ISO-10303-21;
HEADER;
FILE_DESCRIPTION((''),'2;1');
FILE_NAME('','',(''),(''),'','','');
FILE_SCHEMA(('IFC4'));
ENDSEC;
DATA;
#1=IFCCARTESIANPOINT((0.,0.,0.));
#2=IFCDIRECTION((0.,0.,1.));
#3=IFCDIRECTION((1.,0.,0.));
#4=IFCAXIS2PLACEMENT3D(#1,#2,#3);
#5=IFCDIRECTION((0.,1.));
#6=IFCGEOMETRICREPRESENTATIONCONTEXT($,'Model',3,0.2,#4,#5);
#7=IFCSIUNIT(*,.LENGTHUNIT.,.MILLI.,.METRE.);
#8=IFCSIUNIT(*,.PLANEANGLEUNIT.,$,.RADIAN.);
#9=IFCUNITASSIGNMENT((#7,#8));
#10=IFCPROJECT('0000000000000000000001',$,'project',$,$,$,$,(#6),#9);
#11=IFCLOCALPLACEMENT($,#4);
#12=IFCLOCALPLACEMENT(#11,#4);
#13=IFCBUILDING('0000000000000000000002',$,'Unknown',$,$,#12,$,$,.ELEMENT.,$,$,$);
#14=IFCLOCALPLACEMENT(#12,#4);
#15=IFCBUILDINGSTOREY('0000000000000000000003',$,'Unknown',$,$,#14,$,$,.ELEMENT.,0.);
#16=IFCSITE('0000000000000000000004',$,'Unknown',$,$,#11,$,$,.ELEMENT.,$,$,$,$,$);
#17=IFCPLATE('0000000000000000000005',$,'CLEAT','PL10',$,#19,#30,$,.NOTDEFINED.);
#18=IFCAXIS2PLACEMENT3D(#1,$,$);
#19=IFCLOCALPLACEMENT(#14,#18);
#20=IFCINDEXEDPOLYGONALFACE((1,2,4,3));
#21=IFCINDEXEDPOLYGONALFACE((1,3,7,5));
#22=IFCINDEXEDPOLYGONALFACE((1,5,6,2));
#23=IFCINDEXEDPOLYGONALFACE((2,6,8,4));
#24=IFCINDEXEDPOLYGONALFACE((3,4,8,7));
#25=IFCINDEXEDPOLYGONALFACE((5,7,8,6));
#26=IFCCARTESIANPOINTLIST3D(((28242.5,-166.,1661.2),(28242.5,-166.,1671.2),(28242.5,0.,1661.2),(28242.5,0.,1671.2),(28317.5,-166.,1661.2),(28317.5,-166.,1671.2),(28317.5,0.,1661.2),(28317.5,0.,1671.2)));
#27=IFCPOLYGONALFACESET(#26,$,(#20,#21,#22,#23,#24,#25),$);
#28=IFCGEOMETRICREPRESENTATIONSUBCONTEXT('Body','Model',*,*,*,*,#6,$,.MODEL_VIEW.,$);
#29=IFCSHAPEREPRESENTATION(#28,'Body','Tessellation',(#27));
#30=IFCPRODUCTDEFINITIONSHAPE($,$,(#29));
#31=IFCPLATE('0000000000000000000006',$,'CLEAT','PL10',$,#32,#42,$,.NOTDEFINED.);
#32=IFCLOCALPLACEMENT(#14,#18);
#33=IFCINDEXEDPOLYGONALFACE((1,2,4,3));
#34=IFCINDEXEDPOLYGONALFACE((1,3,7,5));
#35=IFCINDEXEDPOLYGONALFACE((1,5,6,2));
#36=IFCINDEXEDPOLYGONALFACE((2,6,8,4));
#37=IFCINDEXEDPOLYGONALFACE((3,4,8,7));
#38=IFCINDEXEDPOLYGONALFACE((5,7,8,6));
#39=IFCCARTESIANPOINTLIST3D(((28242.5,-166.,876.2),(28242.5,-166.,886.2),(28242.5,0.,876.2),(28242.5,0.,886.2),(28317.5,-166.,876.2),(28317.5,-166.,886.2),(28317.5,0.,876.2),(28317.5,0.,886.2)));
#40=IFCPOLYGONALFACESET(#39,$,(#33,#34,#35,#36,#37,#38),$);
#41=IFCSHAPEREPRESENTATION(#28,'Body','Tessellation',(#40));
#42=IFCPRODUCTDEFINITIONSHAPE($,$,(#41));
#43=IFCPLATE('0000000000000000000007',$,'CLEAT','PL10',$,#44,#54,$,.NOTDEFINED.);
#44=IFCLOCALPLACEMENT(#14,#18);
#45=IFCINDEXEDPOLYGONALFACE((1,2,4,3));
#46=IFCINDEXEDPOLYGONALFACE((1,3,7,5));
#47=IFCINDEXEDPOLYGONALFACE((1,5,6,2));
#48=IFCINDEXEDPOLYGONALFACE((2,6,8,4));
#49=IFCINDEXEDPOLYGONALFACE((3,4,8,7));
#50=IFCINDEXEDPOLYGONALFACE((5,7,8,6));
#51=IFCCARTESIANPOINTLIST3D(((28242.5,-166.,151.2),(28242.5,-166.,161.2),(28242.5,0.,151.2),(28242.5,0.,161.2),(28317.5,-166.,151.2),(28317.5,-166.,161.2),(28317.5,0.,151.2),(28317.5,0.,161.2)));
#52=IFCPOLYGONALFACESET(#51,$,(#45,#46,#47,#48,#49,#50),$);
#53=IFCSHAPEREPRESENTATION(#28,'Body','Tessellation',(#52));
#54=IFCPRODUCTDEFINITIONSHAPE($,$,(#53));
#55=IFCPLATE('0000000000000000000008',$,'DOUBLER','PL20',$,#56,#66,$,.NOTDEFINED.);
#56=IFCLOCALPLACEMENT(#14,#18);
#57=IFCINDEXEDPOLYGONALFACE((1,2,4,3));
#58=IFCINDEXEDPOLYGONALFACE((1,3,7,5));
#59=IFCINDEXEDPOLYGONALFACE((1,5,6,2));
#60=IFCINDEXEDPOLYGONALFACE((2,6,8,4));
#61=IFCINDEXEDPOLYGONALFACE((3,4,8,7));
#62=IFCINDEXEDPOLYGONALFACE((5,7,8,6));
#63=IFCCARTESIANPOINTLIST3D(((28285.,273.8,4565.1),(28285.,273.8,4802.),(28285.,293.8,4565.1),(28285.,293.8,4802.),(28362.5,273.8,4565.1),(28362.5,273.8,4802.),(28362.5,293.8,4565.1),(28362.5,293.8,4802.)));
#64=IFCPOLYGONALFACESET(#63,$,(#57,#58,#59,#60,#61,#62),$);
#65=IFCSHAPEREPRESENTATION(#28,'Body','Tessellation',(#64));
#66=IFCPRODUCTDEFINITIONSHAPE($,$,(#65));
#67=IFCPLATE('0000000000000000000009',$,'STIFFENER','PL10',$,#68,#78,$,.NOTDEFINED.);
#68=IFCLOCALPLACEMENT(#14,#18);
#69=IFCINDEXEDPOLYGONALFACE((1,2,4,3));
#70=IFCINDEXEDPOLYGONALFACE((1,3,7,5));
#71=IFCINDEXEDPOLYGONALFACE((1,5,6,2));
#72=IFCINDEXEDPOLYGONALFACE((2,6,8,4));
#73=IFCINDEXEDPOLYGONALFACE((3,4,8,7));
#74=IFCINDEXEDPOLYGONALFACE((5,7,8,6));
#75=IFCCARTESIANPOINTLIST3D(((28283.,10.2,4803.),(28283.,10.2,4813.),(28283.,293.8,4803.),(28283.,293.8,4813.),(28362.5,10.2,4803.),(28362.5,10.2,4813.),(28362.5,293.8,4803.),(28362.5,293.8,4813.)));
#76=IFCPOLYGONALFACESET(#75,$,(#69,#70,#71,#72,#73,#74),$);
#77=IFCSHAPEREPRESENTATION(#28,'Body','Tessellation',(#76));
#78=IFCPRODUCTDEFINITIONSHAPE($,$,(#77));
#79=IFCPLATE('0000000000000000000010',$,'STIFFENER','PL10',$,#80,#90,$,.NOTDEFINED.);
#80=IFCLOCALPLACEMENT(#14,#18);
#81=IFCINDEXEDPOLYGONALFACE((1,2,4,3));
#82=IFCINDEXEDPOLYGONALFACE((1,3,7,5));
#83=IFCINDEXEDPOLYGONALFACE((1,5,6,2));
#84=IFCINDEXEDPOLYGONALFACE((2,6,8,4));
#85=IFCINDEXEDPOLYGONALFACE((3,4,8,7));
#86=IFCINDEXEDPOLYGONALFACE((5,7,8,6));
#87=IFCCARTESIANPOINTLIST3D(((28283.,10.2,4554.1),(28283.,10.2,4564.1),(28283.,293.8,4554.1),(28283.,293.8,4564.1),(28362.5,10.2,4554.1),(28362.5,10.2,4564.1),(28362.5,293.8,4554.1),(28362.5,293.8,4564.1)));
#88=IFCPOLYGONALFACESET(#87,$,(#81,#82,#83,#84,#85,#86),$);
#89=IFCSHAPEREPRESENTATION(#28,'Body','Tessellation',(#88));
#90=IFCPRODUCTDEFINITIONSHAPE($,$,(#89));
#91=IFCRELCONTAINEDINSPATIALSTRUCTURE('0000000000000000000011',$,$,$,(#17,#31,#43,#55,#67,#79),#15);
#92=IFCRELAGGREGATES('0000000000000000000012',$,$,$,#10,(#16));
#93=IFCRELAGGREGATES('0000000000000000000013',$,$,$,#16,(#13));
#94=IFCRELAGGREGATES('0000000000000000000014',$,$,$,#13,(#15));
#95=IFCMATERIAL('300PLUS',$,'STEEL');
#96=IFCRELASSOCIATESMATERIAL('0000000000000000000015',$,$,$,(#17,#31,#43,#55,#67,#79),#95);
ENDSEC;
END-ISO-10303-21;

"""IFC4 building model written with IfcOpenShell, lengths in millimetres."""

from ifc_helpers import new_model, si_unit, direction, frame, origin_with_axes, place, context, subcontext, project, spatial, line, indexed_curve, outline, extrude, material, element, save


model = new_model("IFC4")

# Units and contexts
model_context = context("Model", 3, precision=0.2, world=origin_with_axes(), true_north=direction((0.0, 1.0)))
body_context = subcontext(model_context, "Body", "Model", "MODEL_VIEW")
ifc_project = project(units=[si_unit("LENGTHUNIT", "METRE", prefix="MILLI"), si_unit("PLANEANGLEUNIT", "RADIAN")], contexts=[model_context])

# Site, building, storey
site_placement = place(None, origin_with_axes())
site = spatial("IfcSite", under=ifc_project, at=site_placement, Name="Unknown", CompositionType="ELEMENT")
building_placement = place(site_placement, origin_with_axes())
building = spatial("IfcBuilding", under=site, at=building_placement, Name="Unknown", CompositionType="ELEMENT")
storey_placement = place(building_placement, origin_with_axes())
storey = spatial("IfcBuildingStorey", under=building, at=storey_placement, Name="Unknown", CompositionType="ELEMENT", Elevation=0.0)

# Plates
ifc_material_1 = material(Name="300PLUS", Category="STEEL")
for number, where, z_axis, x_axis, name in (
    (1, (28317.5, 0.0, 1666.2), (0.0, 0.0, 1.0), (-1.0, 0.0, 0.0), "CLEAT"),
    (2, (28317.5, 0.0, 881.2), (0.0, 0.0, 1.0), (-1.0, 0.0, 0.0), "CLEAT"),
    (3, (28317.5, 0.0, 156.2), (0.0, 0.0, 1.0), (-1.0, 0.0, 0.0), "CLEAT"),
):
    element("IfcPlate", number, at=place(storey_placement, frame(where, z_axis=z_axis, x_axis=x_axis)), inside=storey, material=ifc_material_1, Name=name, Description="PL10", PredefinedType="NOTDEFINED", context=body_context, shape_type="SolidModel", body=[
        extrude(outline(indexed_curve([(0.0, 0.0), (75.0, 0.0), (75.0, 166.0), (0.0, 166.0)], segments=[line(1, 2, 3, 4, 1)])), frame((0.0, 0.0, 5.0), z_axis=(0.0, 0.0, 1.0), x_axis=(1.0, 0.0, 0.0)), (0.0, 0.0, -1.0), 10.0),
    ])
plate_1_placement = place(storey_placement, frame((28285.0, 283.8, 4565.1), z_axis=(0.0, -1.0, 0.0), x_axis=(1.0, 0.0, 0.0)))
element("IfcPlate", 4, at=plate_1_placement, inside=storey, material=ifc_material_1, Name="DOUBLER", Description="PL20", PredefinedType="NOTDEFINED", context=body_context, shape_type="SolidModel", body=[
    extrude(outline(indexed_curve([(0.0, 0.0), (77.5, 0.0), (77.5, 236.9), (0.0, 236.9)], segments=[line(1, 2, 3, 4, 1)])), frame((0.0, 0.0, 10.0), z_axis=(0.0, 0.0, 1.0), x_axis=(1.0, 0.0, 0.0)), (0.0, 0.0, -1.0), 20.0),
])
for number, where, z_axis, x_axis, name in (
    (5, (28283.0, 10.2, 4808.0), (0.0, 0.0, 1.0), (1.0, 0.0, 0.0), "STIFFENER"),
    (6, (28283.0, 10.2, 4559.1), (0.0, 0.0, 1.0), (1.0, 0.0, 0.0), "STIFFENER"),
):
    element("IfcPlate", number, at=place(storey_placement, frame(where, z_axis=z_axis, x_axis=x_axis)), inside=storey, material=ifc_material_1, Name=name, Description="PL10", PredefinedType="NOTDEFINED", context=body_context, shape_type="SolidModel", body=[
        extrude(outline(indexed_curve([(0.0, 0.0), (79.5, 0.0), (79.5, 283.6), (0.0, 283.6)], segments=[line(1, 2, 3, 4, 1)])), frame((0.0, 0.0, 5.0), z_axis=(0.0, 0.0, 1.0), x_axis=(1.0, 0.0, 0.0)), (0.0, 0.0, -1.0), 10.0),
    ])

save(model, "model.ifc")
